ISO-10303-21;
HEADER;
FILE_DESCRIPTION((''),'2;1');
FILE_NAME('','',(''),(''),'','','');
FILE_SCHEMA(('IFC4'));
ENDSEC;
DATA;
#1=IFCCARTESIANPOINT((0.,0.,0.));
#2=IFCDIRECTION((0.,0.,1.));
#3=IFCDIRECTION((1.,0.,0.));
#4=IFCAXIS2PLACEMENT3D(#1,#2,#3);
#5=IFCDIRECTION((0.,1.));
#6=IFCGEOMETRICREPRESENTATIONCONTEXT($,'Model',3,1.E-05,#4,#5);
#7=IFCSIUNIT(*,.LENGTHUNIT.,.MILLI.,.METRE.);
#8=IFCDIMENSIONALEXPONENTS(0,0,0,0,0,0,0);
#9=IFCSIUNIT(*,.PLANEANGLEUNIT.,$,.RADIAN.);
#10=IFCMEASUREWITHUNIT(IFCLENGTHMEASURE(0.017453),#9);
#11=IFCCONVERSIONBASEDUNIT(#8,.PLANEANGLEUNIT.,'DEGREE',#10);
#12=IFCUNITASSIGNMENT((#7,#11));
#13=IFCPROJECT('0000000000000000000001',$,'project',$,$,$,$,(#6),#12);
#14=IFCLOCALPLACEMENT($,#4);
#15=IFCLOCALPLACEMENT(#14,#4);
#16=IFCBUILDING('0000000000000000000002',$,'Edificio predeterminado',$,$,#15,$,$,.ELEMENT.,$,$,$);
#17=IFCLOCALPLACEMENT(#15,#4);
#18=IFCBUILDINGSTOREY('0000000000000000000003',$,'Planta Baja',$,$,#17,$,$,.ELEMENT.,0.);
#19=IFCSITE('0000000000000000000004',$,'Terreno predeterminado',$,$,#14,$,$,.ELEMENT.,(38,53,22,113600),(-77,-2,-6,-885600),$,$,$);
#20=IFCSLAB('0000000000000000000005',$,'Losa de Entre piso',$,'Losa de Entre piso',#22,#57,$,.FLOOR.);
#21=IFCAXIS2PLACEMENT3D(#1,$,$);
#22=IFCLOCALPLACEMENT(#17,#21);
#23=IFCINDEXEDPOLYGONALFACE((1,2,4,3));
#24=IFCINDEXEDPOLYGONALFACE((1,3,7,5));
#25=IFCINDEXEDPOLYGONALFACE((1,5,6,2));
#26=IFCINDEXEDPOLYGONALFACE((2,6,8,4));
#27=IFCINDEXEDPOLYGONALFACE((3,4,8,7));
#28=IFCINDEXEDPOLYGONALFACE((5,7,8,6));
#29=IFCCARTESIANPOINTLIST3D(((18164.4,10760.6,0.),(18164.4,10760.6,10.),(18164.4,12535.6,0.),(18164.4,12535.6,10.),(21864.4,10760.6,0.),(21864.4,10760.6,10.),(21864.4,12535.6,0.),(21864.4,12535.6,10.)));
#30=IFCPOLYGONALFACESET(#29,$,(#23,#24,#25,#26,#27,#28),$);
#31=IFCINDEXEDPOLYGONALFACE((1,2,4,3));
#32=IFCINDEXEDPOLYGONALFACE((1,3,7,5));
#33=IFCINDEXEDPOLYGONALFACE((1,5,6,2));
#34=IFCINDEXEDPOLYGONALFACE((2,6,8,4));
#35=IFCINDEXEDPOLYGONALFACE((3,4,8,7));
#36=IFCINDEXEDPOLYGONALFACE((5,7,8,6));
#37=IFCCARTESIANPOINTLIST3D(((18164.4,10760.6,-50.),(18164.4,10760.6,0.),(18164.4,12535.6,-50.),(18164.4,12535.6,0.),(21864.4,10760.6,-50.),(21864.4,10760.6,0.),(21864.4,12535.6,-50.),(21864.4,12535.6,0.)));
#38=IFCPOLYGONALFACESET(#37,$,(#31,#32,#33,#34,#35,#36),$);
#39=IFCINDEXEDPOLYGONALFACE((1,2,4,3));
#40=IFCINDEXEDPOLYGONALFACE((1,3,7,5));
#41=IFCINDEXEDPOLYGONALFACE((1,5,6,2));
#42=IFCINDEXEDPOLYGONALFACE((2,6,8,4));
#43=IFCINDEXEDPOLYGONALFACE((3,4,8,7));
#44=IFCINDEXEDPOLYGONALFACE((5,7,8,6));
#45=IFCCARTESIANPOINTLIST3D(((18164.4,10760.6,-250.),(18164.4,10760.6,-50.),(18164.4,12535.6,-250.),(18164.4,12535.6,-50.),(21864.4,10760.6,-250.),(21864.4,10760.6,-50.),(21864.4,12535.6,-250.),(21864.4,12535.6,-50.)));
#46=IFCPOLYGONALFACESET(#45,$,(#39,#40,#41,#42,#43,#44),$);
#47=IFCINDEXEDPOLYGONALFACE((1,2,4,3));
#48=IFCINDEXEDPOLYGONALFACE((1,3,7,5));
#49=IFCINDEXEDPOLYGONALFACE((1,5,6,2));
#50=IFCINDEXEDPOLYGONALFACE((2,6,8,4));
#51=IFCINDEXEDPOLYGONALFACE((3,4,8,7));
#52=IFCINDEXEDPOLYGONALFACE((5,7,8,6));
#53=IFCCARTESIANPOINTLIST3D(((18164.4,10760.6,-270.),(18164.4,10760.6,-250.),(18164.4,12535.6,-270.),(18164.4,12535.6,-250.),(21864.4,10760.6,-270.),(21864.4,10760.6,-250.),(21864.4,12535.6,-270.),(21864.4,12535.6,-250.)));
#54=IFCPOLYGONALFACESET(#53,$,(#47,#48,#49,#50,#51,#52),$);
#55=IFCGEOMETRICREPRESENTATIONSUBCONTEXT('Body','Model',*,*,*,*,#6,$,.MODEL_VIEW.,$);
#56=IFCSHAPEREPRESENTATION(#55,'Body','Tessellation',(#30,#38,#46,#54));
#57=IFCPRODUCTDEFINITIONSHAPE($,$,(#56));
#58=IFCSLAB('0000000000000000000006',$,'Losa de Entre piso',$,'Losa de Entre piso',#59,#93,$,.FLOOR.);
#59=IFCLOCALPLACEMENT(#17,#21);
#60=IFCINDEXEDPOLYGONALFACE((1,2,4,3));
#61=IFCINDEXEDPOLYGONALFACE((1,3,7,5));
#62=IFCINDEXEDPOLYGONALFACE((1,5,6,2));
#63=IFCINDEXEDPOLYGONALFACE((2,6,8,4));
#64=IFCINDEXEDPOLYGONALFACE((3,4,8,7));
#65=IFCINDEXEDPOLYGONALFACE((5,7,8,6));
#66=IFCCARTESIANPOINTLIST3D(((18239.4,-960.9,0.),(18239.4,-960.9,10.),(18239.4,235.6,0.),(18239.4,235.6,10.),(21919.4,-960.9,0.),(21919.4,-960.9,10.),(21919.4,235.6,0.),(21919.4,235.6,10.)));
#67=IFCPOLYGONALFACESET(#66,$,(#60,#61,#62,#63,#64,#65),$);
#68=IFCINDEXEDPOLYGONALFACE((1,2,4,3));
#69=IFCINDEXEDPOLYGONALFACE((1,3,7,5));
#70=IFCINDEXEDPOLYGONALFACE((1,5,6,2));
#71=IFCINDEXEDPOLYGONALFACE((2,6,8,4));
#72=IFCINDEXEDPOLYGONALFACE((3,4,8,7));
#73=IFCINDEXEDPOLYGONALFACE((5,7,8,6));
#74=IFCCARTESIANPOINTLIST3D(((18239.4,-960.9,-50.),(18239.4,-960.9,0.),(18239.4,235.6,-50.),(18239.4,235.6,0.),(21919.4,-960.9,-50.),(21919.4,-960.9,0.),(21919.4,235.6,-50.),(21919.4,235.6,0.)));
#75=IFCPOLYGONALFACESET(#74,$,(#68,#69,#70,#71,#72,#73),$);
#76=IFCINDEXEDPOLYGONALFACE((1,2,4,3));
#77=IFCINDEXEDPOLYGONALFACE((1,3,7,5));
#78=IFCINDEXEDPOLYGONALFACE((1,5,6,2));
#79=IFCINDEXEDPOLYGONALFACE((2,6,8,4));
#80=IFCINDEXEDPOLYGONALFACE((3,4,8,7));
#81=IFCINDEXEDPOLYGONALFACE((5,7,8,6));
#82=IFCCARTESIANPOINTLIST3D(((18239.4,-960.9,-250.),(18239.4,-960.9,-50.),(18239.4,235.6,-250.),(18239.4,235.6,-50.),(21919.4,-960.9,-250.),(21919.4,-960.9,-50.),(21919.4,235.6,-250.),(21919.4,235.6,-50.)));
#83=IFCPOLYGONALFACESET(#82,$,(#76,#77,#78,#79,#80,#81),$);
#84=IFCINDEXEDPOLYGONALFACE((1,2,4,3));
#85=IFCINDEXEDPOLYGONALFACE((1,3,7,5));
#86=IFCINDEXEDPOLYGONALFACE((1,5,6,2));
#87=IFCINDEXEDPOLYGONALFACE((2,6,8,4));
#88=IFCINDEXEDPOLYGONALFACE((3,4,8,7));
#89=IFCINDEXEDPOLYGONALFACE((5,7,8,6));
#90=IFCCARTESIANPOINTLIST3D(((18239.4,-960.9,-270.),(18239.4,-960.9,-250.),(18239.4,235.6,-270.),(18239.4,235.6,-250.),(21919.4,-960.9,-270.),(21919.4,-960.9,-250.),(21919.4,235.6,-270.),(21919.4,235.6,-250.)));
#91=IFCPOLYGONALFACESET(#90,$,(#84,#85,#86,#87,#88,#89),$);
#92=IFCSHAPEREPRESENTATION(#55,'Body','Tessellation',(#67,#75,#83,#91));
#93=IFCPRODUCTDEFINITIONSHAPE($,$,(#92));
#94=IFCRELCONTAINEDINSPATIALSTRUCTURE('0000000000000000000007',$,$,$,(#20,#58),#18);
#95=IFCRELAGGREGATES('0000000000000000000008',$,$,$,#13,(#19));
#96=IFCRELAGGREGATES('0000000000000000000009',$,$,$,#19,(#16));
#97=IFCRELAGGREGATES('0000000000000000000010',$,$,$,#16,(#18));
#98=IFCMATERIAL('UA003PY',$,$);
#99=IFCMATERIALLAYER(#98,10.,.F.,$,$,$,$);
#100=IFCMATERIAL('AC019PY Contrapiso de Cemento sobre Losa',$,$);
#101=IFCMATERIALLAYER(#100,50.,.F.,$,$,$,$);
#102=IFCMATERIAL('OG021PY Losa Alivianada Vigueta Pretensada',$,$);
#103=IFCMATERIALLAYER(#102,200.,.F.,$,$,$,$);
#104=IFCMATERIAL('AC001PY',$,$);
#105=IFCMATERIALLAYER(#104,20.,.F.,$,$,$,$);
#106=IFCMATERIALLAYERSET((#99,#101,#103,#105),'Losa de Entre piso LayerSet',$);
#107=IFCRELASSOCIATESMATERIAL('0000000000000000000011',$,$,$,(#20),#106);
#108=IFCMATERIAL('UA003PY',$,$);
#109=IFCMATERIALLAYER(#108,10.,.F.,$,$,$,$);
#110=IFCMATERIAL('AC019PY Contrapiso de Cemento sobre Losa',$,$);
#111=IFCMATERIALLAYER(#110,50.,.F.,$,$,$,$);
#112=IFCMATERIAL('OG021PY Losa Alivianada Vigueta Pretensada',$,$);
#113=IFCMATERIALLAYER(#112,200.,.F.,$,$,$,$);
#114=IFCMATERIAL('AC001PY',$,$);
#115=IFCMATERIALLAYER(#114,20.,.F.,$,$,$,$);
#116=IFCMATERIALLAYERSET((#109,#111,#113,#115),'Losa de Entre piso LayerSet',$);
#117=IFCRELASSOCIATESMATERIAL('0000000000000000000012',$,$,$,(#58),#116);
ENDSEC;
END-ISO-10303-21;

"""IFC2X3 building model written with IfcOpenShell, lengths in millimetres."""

from ifc_helpers import new_model, entity, si_unit, converted_unit, direction, frame, origin_with_axes, place, context, subcontext, project, spatial, polyline, outline, extrude, material, layer, layer_set, layer_usage, element, save


model = new_model("IFC2X3")

# Units and contexts
model_context = context("Model", 3, precision=1e-05, world=origin_with_axes(), true_north=direction((0.0, 1.0)))
body_context = subcontext(model_context, "Body", "Model", "MODEL_VIEW")
ifc_project = project(units=[si_unit("LENGTHUNIT", "METRE", prefix="MILLI"), converted_unit("PLANEANGLEUNIT", "DEGREE", entity("IfcLengthMeasure", 0.017453), si_unit("PLANEANGLEUNIT", "RADIAN"), dimensions=[0, 0, 0, 0, 0, 0, 0])], contexts=[model_context])

# Site, building, storey
site_placement = place(None, origin_with_axes())
site = spatial("IfcSite", under=ifc_project, at=site_placement, Name="Terreno predeterminado", CompositionType="ELEMENT", RefLatitude=(38, 53, 22, 113600), RefLongitude=(-77, -2, -6, -885600))
building_placement = place(site_placement, origin_with_axes())
building = spatial("IfcBuilding", under=site, at=building_placement, Name="Edificio predeterminado", CompositionType="ELEMENT")
storey_placement = place(building_placement, origin_with_axes())
storey = spatial("IfcBuildingStorey", under=building, at=storey_placement, Name="Planta Baja", CompositionType="ELEMENT", Elevation=0.0)

# Slabs
ifc_material_1 = material(Name="UA003PY")
ifc_layer_1 = layer(ifc_material_1, 10.0, ventilated=False)
ifc_material_2 = material(Name="AC019PY Contrapiso de Cemento sobre Losa")
ifc_layer_2 = layer(ifc_material_2, 50.0, ventilated=False)
ifc_material_3 = material(Name="OG021PY Losa Alivianada Vigueta Pretensada")
ifc_layer_3 = layer(ifc_material_3, 200.0, ventilated=False)
ifc_material_4 = material(Name="AC001PY")
ifc_layer_4 = layer(ifc_material_4, 20.0, ventilated=False)
ifc_layer_set_1 = layer_set([ifc_layer_1, ifc_layer_2, ifc_layer_3, ifc_layer_4], Name="Losa de Entre piso LayerSet")
ifc_layer_usage_1 = layer_usage(ifc_layer_set_1, "AXIS3", "POSITIVE", 0.0)
slab_1_placement = place(storey_placement, origin_with_axes())
element("IfcSlab", 1, at=slab_1_placement, inside=storey, material=ifc_layer_usage_1, Name="Losa de Entre piso", ObjectType="Losa de Entre piso", PredefinedType="FLOOR", context=body_context, shape_type="SweptSolid", body=[
    extrude(outline(polyline([(0.0, 0.0), (1775.0, 0.0), (1775.0, 3700.0), (0.0, 3700.0), (0.0, 0.0)])), frame((21864.4, 12535.6, 0.0), z_axis=(0.0, 0.0, -1.0), x_axis=(0.0, -1.0, 0.0)), (0.0, 0.0, -1.0), 10.0),
    extrude(outline(polyline([(0.0, 0.0), (1775.0, 0.0), (1775.0, 3700.0), (0.0, 3700.0), (0.0, 0.0)])), frame((21864.4, 12535.6, -50.0), z_axis=(0.0, 0.0, -1.0), x_axis=(0.0, -1.0, 0.0)), (0.0, 0.0, -1.0), 50.0),
    extrude(outline(polyline([(0.0, 0.0), (1775.0, 0.0), (1775.0, 3700.0), (0.0, 3700.0), (0.0, 0.0)])), frame((21864.4, 12535.6, -250.0), z_axis=(0.0, 0.0, -1.0), x_axis=(0.0, -1.0, 0.0)), (0.0, 0.0, -1.0), 200.0),
    extrude(outline(polyline([(0.0, 0.0), (1775.0, 0.0), (1775.0, 3700.0), (0.0, 3700.0), (0.0, 0.0)])), frame((21864.4, 12535.6, -270.0), z_axis=(0.0, 0.0, -1.0), x_axis=(0.0, -1.0, 0.0)), (0.0, 0.0, -1.0), 20.0),
])
ifc_material_5 = material(Name="UA003PY")
ifc_layer_5 = layer(ifc_material_5, 10.0, ventilated=False)
ifc_material_6 = material(Name="AC019PY Contrapiso de Cemento sobre Losa")
ifc_layer_6 = layer(ifc_material_6, 50.0, ventilated=False)
ifc_material_7 = material(Name="OG021PY Losa Alivianada Vigueta Pretensada")
ifc_layer_7 = layer(ifc_material_7, 200.0, ventilated=False)
ifc_material_8 = material(Name="AC001PY")
ifc_layer_8 = layer(ifc_material_8, 20.0, ventilated=False)
ifc_layer_set_2 = layer_set([ifc_layer_5, ifc_layer_6, ifc_layer_7, ifc_layer_8], Name="Losa de Entre piso LayerSet")
ifc_layer_usage_2 = layer_usage(ifc_layer_set_2, "AXIS3", "POSITIVE", 0.0)
slab_2_placement = place(storey_placement, origin_with_axes())
element("IfcSlab", 2, at=slab_2_placement, inside=storey, material=ifc_layer_usage_2, Name="Losa de Entre piso", ObjectType="Losa de Entre piso", PredefinedType="FLOOR", context=body_context, shape_type="SweptSolid", body=[
    extrude(outline(polyline([(0.0, 0.0), (1196.6, 0.0), (1196.6, 3680.0), (0.0, 3680.0), (0.0, 0.0)])), frame((21919.4, 235.6, 0.0), z_axis=(0.0, 0.0, -1.0), x_axis=(0.0, -1.0, 0.0)), (0.0, 0.0, -1.0), 10.0),
    extrude(outline(polyline([(0.0, 0.0), (1196.6, 0.0), (1196.6, 3680.0), (0.0, 3680.0), (0.0, 0.0)])), frame((21919.4, 235.6, -50.0), z_axis=(0.0, 0.0, -1.0), x_axis=(0.0, -1.0, 0.0)), (0.0, 0.0, -1.0), 50.0),
    extrude(outline(polyline([(0.0, 0.0), (1196.6, 0.0), (1196.6, 3680.0), (0.0, 3680.0), (0.0, 0.0)])), frame((21919.4, 235.6, -250.0), z_axis=(0.0, 0.0, -1.0), x_axis=(0.0, -1.0, 0.0)), (0.0, 0.0, -1.0), 200.0),
    extrude(outline(polyline([(0.0, 0.0), (1196.6, 0.0), (1196.6, 3680.0), (0.0, 3680.0), (0.0, 0.0)])), frame((21919.4, 235.6, -270.0), z_axis=(0.0, 0.0, -1.0), x_axis=(0.0, -1.0, 0.0)), (0.0, 0.0, -1.0), 20.0),
])

save(model, "model.ifc")
